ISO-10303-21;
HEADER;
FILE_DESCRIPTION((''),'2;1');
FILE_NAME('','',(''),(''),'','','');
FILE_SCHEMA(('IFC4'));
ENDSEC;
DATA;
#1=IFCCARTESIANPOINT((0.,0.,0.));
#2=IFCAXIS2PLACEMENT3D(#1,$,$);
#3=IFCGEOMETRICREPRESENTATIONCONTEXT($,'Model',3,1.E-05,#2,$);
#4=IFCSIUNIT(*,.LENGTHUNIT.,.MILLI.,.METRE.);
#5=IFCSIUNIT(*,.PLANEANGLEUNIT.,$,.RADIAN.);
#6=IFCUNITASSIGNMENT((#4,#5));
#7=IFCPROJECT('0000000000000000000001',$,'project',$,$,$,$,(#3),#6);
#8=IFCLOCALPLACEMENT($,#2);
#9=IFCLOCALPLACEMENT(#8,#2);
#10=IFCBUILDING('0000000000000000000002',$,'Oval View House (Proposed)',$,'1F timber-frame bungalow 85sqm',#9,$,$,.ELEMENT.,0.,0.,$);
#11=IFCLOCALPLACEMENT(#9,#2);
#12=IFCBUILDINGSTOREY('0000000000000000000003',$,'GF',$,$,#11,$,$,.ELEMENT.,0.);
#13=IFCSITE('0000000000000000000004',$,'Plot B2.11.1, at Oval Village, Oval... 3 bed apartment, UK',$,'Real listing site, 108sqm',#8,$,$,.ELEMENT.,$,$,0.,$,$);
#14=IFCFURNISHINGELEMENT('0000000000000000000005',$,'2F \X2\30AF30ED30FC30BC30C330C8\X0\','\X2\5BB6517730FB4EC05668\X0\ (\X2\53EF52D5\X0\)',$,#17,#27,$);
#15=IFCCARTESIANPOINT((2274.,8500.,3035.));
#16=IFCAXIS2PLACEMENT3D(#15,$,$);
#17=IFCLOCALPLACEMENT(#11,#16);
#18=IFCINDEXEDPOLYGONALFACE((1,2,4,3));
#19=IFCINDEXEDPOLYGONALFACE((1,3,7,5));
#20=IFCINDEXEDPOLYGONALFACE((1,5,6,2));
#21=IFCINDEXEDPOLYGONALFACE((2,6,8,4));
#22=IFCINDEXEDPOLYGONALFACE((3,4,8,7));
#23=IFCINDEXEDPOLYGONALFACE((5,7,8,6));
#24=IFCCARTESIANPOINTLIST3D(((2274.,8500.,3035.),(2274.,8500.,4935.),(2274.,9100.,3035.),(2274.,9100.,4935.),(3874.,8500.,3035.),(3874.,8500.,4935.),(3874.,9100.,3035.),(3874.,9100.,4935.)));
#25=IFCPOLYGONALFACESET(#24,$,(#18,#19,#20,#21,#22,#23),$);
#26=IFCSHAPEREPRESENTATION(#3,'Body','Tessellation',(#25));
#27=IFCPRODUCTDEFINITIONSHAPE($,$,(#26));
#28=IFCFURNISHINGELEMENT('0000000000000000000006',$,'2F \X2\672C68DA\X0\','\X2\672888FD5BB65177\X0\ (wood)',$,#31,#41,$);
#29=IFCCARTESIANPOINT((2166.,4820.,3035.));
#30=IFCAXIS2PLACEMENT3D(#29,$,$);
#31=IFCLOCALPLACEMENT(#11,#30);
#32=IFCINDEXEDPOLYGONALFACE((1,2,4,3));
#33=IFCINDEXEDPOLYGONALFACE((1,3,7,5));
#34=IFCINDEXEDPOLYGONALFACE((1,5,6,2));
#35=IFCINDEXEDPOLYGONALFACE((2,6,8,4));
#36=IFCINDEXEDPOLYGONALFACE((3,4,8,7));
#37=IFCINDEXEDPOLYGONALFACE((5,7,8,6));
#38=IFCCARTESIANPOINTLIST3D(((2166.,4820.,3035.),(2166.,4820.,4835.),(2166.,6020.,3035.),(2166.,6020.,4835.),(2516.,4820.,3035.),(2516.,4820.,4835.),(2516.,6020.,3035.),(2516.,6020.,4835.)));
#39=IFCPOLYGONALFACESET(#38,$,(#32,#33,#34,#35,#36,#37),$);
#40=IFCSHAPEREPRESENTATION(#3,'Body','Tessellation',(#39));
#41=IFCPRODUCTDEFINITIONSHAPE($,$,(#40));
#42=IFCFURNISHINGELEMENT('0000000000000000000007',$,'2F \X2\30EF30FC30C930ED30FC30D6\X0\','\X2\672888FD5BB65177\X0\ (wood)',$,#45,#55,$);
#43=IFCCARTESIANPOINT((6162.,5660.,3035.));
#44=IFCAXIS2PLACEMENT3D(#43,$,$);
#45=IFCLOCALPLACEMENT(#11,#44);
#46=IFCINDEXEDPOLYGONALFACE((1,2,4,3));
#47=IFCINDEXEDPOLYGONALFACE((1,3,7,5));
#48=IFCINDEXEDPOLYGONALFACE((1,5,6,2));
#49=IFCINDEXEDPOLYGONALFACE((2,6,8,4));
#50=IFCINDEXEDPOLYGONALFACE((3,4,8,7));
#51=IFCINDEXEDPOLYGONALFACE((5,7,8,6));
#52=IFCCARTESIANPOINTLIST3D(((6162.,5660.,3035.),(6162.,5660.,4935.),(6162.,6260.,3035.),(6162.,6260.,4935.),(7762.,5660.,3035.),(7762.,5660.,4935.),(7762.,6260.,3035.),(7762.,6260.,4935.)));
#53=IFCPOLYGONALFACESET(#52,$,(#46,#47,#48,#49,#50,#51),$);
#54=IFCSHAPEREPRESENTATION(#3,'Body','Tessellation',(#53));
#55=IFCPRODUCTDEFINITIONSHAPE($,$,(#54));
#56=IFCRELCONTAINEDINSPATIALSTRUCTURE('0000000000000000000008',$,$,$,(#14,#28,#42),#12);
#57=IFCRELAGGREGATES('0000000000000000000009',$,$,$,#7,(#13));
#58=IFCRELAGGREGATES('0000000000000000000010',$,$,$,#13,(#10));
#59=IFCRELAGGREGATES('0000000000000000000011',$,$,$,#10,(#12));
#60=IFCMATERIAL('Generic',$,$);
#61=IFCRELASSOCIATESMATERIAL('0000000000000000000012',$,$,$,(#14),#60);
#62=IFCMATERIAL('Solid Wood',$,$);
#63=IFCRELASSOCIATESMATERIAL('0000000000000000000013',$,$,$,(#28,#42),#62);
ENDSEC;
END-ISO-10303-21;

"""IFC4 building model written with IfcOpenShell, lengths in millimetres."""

from ifc_helpers import new_model, si_unit, frame, frame_2d, origin, place, context, project, spatial, rectangle, extrude, material, element, save


model = new_model("IFC4")

# Units and contexts
model_context = context("Model", 3, precision=1e-05, world=origin())
ifc_project = project(units=[si_unit("LENGTHUNIT", "METRE", prefix="MILLI"), si_unit("PLANEANGLEUNIT", "RADIAN")], contexts=[model_context])

# Site, building, storey
site_placement = place(None, origin())
site = spatial("IfcSite", under=ifc_project, at=site_placement, Name="Plot B2.11.1, at Oval Village, Oval... 3 bed apartment, UK", ObjectType="Real listing site, 108sqm", CompositionType="ELEMENT", RefElevation=0.0)
building_placement = place(site_placement, origin())
building = spatial("IfcBuilding", under=site, at=building_placement, Name="Oval View House (Proposed)", ObjectType="1F timber-frame bungalow 85sqm", CompositionType="ELEMENT", ElevationOfRefHeight=0.0, ElevationOfTerrain=0.0)
storey_placement = place(building_placement, origin())
storey = spatial("IfcBuildingStorey", under=building, at=storey_placement, Name="GF", CompositionType="ELEMENT", Elevation=0.0)

# Shared definitions
ifc_material_1 = material(Name="Solid Wood")

# Shared definitions
ifc_material_2 = material(Name="Generic")

# Furnishing elements
furnishing_1_placement = place(storey_placement, frame((2274.0, 8500.0, 3035.0)))
element("IfcFurnishingElement", 1, at=furnishing_1_placement, inside=storey, material=ifc_material_2, Name="2F クローゼット", Description="家具・什器 (可動)", context=model_context, shape_type="SweptSolid", body=[
    extrude(rectangle(XDim=1600.0, YDim=600.0, at=frame_2d((800.0, 300.0))), frame((2274.0, 8500.0, 3035.0)), (0.0, 0.0, 1.0), 1900.0),
])
furnishing_2_placement = place(storey_placement, frame((2166.0, 4820.0, 3035.0)))
element("IfcFurnishingElement", 2, at=furnishing_2_placement, inside=storey, material=ifc_material_1, Name="2F 本棚", Description="木製家具 (wood)", context=model_context, shape_type="SweptSolid", body=[
    extrude(rectangle(XDim=350.0, YDim=1200.0, at=frame_2d((175.0, 600.0))), frame((2166.0, 4820.0, 3035.0)), (0.0, 0.0, 1.0), 1800.0),
])
furnishing_3_placement = place(storey_placement, frame((6162.0, 5660.0, 3035.0)))
element("IfcFurnishingElement", 3, at=furnishing_3_placement, inside=storey, material=ifc_material_1, Name="2F ワードローブ", Description="木製家具 (wood)", context=model_context, shape_type="SweptSolid", body=[
    extrude(rectangle(XDim=1600.0, YDim=600.0, at=frame_2d((800.0, 300.0))), frame((6162.0, 5660.0, 3035.0)), (0.0, 0.0, 1.0), 1900.0),
])

save(model, "model.ifc")
